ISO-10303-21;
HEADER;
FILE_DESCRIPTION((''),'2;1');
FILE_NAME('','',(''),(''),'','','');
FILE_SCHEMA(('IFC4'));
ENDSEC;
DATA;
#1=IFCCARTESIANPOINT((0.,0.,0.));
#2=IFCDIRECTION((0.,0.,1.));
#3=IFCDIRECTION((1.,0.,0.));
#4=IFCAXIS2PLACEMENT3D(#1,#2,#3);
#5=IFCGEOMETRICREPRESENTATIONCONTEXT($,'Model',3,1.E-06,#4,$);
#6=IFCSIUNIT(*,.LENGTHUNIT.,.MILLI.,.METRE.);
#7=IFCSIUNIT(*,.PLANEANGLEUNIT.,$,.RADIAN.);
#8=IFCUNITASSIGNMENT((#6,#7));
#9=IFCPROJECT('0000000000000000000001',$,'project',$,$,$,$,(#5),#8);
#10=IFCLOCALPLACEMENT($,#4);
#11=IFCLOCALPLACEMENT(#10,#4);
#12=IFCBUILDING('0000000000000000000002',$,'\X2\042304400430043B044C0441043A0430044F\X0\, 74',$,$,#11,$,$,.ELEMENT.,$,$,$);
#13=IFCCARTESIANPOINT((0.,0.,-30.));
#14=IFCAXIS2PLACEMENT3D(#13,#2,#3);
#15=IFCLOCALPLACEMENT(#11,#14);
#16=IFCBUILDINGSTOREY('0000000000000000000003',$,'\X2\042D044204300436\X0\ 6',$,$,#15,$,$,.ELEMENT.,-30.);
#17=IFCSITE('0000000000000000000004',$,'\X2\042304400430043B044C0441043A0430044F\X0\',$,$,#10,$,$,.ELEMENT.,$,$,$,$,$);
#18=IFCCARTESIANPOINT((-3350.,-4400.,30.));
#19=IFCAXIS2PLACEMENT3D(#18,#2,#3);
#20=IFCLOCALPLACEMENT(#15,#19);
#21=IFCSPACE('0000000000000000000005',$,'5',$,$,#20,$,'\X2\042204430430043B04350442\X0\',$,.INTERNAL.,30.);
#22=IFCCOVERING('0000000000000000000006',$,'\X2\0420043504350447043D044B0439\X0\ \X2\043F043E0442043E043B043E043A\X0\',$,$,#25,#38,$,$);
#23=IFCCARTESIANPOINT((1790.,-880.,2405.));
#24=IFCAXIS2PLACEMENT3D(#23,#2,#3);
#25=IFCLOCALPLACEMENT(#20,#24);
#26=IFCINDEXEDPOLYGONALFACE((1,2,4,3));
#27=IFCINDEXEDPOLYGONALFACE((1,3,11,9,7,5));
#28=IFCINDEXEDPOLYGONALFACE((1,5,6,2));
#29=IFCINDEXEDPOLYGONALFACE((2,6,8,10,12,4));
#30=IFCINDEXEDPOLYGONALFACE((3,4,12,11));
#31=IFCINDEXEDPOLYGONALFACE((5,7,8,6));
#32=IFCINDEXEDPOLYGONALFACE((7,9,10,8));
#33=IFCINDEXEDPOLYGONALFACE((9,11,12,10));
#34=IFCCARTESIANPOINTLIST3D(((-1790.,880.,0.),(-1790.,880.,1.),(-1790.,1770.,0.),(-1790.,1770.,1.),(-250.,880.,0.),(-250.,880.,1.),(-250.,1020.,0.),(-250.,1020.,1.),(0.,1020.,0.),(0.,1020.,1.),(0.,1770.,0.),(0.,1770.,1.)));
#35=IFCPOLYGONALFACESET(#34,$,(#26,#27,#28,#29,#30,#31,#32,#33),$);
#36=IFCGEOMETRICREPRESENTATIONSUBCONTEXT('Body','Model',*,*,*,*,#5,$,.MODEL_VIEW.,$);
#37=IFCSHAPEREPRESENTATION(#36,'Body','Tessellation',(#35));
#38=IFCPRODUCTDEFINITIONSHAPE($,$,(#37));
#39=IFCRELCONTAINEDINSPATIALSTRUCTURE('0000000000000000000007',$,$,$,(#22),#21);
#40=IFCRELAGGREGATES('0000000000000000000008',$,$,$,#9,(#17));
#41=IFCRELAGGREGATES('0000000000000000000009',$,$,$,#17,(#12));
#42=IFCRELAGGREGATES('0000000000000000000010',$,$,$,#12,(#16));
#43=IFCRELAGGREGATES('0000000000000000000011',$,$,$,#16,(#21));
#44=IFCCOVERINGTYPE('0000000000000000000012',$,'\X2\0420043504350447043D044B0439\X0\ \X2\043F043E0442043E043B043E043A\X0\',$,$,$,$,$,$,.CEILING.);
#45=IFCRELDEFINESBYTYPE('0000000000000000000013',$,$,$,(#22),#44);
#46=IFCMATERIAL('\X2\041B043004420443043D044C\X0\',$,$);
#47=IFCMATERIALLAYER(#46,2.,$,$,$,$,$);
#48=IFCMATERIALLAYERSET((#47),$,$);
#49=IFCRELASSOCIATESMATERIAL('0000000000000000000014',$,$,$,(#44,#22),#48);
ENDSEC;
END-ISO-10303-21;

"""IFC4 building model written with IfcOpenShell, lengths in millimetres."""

from ifc_helpers import new_model, si_unit, frame, origin_with_axes, place, context, subcontext, project, spatial, line, indexed_curve, outline, extrude, material, layer, layer_set, layer_usage, type_object, element, save


model = new_model("IFC4")

# Units and contexts
model_context = context("Model", 3, precision=1e-06, world=origin_with_axes())
body_context = subcontext(model_context, "Body", "Model", "MODEL_VIEW")
ifc_project = project(units=[si_unit("LENGTHUNIT", "METRE", prefix="MILLI"), si_unit("PLANEANGLEUNIT", "RADIAN")], contexts=[model_context])

# Site, building, storey
site_placement = place(None, origin_with_axes())
site = spatial("IfcSite", under=ifc_project, at=site_placement, Name="Уральская", CompositionType="ELEMENT")
building_placement = place(site_placement, origin_with_axes())
building = spatial("IfcBuilding", under=site, at=building_placement, Name="Уральская, 74", CompositionType="ELEMENT")
storey_placement = place(building_placement, frame((0.0, 0.0, -30.0), z_axis=(0.0, 0.0, 1.0), x_axis=(1.0, 0.0, 0.0)))
storey = spatial("IfcBuildingStorey", under=building, at=storey_placement, Name="Этаж 6", CompositionType="ELEMENT", Elevation=-30.0)

# Shared definitions
ifc_material_1 = material(Name="Латунь")
ifc_layer = layer(ifc_material_1, 2.0)
ifc_layer_set = layer_set([ifc_layer])
ifc_layer_usage = layer_usage(ifc_layer_set, "AXIS3", "POSITIVE", 0.0)
covering_type = type_object("IfcCoveringType", Name="Реечный потолок", PredefinedType="CEILING", material=ifc_layer_set)

# Shared definitions
space_1_placement = place(storey_placement, frame((-3350.0, -4400.0, 30.0), z_axis=(0.0, 0.0, 1.0), x_axis=(1.0, 0.0, 0.0)))
space_1 = spatial("IfcSpace", under=storey, at=space_1_placement, Name="5", LongName="Туалет", PredefinedType="INTERNAL", ElevationWithFlooring=30.0)

# Covering
covering_1_placement = place(space_1_placement, frame((1790.0, -880.0, 2405.0), z_axis=(0.0, 0.0, 1.0), x_axis=(1.0, 0.0, 0.0)))
element("IfcCovering", 1, at=covering_1_placement, inside=space_1, type_object=covering_type, material=ifc_layer_usage, Name="Реечный потолок", context=body_context, shape_type="SweptSolid", body=[
    extrude(outline(indexed_curve([(0.0, 1770.0), (-1790.0, 1770.0), (-1790.0, 880.0), (-250.0, 880.0), (-250.0, 1020.0), (0.0, 1020.0)], segments=[line(6, 5), line(5, 4), line(4, 3), line(3, 2), line(2, 1), line(1, 6)], self_intersect=False)), None, (0.0, 0.0, 1.0), 1.0),
])

save(model, "model.ifc")
